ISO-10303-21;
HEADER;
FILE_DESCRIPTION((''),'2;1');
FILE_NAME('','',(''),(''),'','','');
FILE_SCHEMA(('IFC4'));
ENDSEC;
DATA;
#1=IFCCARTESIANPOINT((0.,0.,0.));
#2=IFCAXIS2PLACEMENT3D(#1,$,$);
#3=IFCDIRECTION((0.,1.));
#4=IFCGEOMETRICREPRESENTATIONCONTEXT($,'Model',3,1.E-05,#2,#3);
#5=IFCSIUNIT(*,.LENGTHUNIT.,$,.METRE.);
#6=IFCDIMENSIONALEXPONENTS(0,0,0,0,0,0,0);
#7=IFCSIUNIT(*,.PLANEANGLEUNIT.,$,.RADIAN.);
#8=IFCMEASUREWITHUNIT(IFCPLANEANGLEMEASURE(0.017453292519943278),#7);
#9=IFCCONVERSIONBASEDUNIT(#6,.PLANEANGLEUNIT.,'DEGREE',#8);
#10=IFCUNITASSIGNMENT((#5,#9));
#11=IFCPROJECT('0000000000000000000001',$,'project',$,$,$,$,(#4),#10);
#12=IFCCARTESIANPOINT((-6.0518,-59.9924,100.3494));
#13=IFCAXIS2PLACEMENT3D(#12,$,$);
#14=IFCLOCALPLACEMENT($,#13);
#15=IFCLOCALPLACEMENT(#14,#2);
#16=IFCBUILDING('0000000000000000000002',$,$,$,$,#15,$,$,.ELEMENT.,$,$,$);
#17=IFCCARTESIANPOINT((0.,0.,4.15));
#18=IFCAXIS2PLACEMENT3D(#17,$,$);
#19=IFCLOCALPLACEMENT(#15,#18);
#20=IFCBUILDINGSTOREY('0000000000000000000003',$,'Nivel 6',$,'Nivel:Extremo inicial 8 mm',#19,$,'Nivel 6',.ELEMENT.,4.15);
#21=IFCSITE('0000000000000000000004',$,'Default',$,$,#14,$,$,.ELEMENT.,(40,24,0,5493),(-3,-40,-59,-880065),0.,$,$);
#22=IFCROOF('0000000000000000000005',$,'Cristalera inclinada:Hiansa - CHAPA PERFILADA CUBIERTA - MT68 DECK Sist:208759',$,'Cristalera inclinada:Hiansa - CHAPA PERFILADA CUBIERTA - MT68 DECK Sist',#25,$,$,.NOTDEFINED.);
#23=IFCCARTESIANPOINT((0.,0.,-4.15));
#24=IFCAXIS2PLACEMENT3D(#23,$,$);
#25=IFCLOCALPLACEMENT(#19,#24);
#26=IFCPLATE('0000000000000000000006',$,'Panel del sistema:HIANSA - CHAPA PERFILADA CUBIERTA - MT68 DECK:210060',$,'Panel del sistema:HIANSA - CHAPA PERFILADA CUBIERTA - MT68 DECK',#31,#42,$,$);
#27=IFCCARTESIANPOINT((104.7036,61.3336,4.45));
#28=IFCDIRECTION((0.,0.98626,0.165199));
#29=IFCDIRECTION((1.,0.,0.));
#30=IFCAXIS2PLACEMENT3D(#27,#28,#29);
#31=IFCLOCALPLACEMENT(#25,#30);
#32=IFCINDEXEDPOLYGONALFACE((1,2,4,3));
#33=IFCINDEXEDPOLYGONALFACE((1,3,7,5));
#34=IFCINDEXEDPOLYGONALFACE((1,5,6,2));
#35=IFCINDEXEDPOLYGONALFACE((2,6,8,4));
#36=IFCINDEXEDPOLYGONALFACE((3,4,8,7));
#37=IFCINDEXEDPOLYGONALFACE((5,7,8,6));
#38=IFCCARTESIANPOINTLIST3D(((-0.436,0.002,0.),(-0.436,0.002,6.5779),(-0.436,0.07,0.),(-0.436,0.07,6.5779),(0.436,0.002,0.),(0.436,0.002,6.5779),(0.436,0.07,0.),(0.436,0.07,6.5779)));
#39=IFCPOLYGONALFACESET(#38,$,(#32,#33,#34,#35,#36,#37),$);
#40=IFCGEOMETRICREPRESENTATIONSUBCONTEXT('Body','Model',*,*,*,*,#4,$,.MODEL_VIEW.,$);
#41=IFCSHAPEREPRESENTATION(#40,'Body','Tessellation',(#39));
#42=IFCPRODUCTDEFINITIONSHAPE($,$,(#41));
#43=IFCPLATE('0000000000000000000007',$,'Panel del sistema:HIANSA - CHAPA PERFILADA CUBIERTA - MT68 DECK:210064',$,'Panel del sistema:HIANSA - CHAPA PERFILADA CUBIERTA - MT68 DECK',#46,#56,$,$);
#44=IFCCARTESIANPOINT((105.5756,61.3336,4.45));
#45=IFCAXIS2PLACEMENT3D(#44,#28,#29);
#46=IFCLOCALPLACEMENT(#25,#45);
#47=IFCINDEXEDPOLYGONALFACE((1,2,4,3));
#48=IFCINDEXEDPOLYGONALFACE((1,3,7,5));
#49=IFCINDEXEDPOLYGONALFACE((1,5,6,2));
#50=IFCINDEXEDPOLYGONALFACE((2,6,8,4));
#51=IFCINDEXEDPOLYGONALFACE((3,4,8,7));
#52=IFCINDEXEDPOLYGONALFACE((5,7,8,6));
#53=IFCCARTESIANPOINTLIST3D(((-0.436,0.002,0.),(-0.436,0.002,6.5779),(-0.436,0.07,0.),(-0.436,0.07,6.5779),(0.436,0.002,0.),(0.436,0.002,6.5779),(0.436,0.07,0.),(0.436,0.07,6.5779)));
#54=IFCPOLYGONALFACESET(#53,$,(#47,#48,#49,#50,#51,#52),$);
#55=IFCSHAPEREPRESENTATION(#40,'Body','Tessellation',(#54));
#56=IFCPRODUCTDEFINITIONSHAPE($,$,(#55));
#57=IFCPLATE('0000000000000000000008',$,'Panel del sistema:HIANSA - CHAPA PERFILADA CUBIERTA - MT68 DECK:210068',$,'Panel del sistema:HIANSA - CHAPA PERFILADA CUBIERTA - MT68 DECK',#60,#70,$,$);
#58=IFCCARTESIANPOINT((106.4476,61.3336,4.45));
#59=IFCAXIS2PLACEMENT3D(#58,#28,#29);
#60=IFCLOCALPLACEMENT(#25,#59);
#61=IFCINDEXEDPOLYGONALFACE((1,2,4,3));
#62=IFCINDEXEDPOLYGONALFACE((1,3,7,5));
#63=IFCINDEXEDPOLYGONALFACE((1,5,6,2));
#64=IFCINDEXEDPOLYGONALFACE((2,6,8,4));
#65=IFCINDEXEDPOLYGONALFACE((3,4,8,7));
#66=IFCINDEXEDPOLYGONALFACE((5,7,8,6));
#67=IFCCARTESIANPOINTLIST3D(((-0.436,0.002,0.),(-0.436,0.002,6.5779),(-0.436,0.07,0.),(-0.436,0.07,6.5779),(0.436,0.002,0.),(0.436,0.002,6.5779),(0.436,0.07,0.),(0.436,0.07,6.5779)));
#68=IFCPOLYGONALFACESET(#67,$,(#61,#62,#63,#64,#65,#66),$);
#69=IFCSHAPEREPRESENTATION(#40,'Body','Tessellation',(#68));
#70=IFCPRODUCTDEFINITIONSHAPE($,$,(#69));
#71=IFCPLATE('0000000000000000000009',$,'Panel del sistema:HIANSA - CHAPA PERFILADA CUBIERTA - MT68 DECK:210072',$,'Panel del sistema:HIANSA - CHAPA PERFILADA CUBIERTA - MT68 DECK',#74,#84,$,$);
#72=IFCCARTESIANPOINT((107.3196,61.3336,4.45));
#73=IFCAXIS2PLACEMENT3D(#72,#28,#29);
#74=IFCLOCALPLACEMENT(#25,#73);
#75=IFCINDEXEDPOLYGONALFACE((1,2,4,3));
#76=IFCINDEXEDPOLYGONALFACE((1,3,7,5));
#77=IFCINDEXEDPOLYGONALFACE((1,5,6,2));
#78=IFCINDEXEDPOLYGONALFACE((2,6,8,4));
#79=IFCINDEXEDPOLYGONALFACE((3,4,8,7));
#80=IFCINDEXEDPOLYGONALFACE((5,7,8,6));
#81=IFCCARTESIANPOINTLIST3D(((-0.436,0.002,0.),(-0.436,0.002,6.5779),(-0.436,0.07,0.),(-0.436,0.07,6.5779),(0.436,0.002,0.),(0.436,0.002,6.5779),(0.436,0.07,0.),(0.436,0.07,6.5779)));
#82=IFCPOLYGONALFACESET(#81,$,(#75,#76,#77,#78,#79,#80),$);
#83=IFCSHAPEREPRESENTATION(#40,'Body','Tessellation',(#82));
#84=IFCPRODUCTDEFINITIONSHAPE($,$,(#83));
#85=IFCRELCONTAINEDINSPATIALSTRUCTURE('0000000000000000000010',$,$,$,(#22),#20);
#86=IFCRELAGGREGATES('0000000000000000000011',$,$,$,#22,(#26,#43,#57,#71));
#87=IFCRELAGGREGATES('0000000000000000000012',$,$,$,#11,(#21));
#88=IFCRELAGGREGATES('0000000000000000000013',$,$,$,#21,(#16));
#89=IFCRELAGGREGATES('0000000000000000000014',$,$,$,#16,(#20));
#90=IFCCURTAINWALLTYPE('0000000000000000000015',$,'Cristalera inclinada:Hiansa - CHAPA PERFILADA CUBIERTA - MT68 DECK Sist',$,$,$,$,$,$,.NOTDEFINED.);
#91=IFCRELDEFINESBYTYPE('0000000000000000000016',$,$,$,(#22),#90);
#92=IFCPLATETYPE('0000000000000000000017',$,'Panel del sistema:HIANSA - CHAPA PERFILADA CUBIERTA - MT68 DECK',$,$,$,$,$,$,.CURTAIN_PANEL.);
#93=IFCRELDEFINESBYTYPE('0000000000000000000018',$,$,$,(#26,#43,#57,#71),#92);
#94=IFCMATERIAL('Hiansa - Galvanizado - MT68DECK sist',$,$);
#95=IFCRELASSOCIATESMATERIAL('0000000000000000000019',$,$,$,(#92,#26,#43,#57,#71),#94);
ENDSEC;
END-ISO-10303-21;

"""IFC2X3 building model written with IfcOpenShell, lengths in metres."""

from ifc_helpers import new_model, entity, si_unit, converted_unit, direction, frame, origin, origin_2d_with_axis, place, context, subcontext, project, spatial, rectangle, extrude, source, transform, mapped, material, type_object, type_shapes, element, aggregate, save


model = new_model("IFC2X3")

# Units and contexts
model_context = context("Model", 3, precision=1e-05, world=origin(), true_north=direction((0.0, 1.0)))
body_context = subcontext(model_context, "Body", "Model", "MODEL_VIEW")
ifc_project = project(units=[si_unit("LENGTHUNIT", "METRE"), converted_unit("PLANEANGLEUNIT", "DEGREE", entity("IfcPlaneAngleMeasure", 0.017453292519943278), si_unit("PLANEANGLEUNIT", "RADIAN"), dimensions=[0, 0, 0, 0, 0, 0, 0])], contexts=[model_context])

# Site, building, storey
site_placement = place(None, frame((-6.0518, -59.9924, 100.3494)))
site = spatial("IfcSite", under=ifc_project, at=site_placement, Name="Default", CompositionType="ELEMENT", RefLatitude=(40, 24, 0, 5493), RefLongitude=(-3, -40, -59, -880065), RefElevation=0.0)
building_placement = place(site_placement, origin())
building = spatial("IfcBuilding", under=site, at=building_placement, CompositionType="ELEMENT")
storey_placement = place(building_placement, frame((0.0, 0.0, 4.15)))
storey = spatial("IfcBuildingStorey", under=building, at=storey_placement, Name="Nivel 6", ObjectType="Nivel:Extremo inicial 8 mm", LongName="Nivel 6", CompositionType="ELEMENT", Elevation=4.15)

# Roof, plates
curtain_wall_type = type_object("IfcCurtainWallType", Name="Cristalera inclinada:Hiansa - CHAPA PERFILADA CUBIERTA - MT68 DECK Sist", PredefinedType="NOTDEFINED")
roof_placement = place(storey_placement, frame((0.0, 0.0, -4.15)))
roof = element("IfcRoof", 1, at=roof_placement, inside=storey, type_object=curtain_wall_type, Name="Cristalera inclinada:Hiansa - CHAPA PERFILADA CUBIERTA - MT68 DECK Sist:208759", ObjectType="Cristalera inclinada:Hiansa - CHAPA PERFILADA CUBIERTA - MT68 DECK Sist", ShapeType="NOTDEFINED")
ifc_material_1 = material(Name="Hiansa - Galvanizado - MT68DECK sist")
plate_type_1 = type_object("IfcPlateType", Name="Panel del sistema:HIANSA - CHAPA PERFILADA CUBIERTA - MT68 DECK", PredefinedType="CURTAIN_PANEL", material=ifc_material_1)
shared_shape_1 = source(origin(), body_context, "Body", "SweptSolid", [
    extrude(rectangle(XDim=0.068, YDim=0.872, at=origin_2d_with_axis()), frame((0.0, 0.036, 0.0), z_axis=(0.0, 0.0, 1.0), x_axis=(0.0, 1.0, 0.0)), (0.0, 0.0, 1.0), 6.5779),
])
type_shapes(plate_type_1, [shared_shape_1])
plate_1_placement = place(roof_placement, frame((104.7036, 61.3336, 4.45), z_axis=(0.0, 0.98626, 0.165199), x_axis=(1.0, 0.0, 0.0)))
plate_1 = element("IfcPlate", 2, at=plate_1_placement, type_object=plate_type_1, material=ifc_material_1, Name="Panel del sistema:HIANSA - CHAPA PERFILADA CUBIERTA - MT68 DECK:210060", ObjectType="Panel del sistema:HIANSA - CHAPA PERFILADA CUBIERTA - MT68 DECK", context=body_context, shape_type="MappedRepresentation", body=[
    mapped(shared_shape_1, transform((0.0, 0.0, 0.0), scale=1.0)),
])
plate_2_placement = place(roof_placement, frame((105.5756, 61.3336, 4.45), z_axis=(0.0, 0.98626, 0.165199), x_axis=(1.0, 0.0, 0.0)))
plate_2 = element("IfcPlate", 3, at=plate_2_placement, type_object=plate_type_1, material=ifc_material_1, Name="Panel del sistema:HIANSA - CHAPA PERFILADA CUBIERTA - MT68 DECK:210064", ObjectType="Panel del sistema:HIANSA - CHAPA PERFILADA CUBIERTA - MT68 DECK", context=body_context, shape_type="MappedRepresentation", body=[
    mapped(shared_shape_1, transform((0.0, 0.0, 0.0), scale=1.0)),
])
plate_3_placement = place(roof_placement, frame((106.4476, 61.3336, 4.45), z_axis=(0.0, 0.98626, 0.165199), x_axis=(1.0, 0.0, 0.0)))
plate_3 = element("IfcPlate", 4, at=plate_3_placement, type_object=plate_type_1, material=ifc_material_1, Name="Panel del sistema:HIANSA - CHAPA PERFILADA CUBIERTA - MT68 DECK:210068", ObjectType="Panel del sistema:HIANSA - CHAPA PERFILADA CUBIERTA - MT68 DECK", context=body_context, shape_type="MappedRepresentation", body=[
    mapped(shared_shape_1, transform((0.0, 0.0, 0.0), scale=1.0)),
])
plate_4_placement = place(roof_placement, frame((107.3196, 61.3336, 4.45), z_axis=(0.0, 0.98626, 0.165199), x_axis=(1.0, 0.0, 0.0)))
plate_4 = element("IfcPlate", 5, at=plate_4_placement, type_object=plate_type_1, material=ifc_material_1, Name="Panel del sistema:HIANSA - CHAPA PERFILADA CUBIERTA - MT68 DECK:210072", ObjectType="Panel del sistema:HIANSA - CHAPA PERFILADA CUBIERTA - MT68 DECK", context=body_context, shape_type="MappedRepresentation", body=[
    mapped(shared_shape_1, transform((0.0, 0.0, 0.0), scale=1.0)),
])
aggregate(roof, [plate_1, plate_2, plate_3, plate_4])

save(model, "model.ifc")
